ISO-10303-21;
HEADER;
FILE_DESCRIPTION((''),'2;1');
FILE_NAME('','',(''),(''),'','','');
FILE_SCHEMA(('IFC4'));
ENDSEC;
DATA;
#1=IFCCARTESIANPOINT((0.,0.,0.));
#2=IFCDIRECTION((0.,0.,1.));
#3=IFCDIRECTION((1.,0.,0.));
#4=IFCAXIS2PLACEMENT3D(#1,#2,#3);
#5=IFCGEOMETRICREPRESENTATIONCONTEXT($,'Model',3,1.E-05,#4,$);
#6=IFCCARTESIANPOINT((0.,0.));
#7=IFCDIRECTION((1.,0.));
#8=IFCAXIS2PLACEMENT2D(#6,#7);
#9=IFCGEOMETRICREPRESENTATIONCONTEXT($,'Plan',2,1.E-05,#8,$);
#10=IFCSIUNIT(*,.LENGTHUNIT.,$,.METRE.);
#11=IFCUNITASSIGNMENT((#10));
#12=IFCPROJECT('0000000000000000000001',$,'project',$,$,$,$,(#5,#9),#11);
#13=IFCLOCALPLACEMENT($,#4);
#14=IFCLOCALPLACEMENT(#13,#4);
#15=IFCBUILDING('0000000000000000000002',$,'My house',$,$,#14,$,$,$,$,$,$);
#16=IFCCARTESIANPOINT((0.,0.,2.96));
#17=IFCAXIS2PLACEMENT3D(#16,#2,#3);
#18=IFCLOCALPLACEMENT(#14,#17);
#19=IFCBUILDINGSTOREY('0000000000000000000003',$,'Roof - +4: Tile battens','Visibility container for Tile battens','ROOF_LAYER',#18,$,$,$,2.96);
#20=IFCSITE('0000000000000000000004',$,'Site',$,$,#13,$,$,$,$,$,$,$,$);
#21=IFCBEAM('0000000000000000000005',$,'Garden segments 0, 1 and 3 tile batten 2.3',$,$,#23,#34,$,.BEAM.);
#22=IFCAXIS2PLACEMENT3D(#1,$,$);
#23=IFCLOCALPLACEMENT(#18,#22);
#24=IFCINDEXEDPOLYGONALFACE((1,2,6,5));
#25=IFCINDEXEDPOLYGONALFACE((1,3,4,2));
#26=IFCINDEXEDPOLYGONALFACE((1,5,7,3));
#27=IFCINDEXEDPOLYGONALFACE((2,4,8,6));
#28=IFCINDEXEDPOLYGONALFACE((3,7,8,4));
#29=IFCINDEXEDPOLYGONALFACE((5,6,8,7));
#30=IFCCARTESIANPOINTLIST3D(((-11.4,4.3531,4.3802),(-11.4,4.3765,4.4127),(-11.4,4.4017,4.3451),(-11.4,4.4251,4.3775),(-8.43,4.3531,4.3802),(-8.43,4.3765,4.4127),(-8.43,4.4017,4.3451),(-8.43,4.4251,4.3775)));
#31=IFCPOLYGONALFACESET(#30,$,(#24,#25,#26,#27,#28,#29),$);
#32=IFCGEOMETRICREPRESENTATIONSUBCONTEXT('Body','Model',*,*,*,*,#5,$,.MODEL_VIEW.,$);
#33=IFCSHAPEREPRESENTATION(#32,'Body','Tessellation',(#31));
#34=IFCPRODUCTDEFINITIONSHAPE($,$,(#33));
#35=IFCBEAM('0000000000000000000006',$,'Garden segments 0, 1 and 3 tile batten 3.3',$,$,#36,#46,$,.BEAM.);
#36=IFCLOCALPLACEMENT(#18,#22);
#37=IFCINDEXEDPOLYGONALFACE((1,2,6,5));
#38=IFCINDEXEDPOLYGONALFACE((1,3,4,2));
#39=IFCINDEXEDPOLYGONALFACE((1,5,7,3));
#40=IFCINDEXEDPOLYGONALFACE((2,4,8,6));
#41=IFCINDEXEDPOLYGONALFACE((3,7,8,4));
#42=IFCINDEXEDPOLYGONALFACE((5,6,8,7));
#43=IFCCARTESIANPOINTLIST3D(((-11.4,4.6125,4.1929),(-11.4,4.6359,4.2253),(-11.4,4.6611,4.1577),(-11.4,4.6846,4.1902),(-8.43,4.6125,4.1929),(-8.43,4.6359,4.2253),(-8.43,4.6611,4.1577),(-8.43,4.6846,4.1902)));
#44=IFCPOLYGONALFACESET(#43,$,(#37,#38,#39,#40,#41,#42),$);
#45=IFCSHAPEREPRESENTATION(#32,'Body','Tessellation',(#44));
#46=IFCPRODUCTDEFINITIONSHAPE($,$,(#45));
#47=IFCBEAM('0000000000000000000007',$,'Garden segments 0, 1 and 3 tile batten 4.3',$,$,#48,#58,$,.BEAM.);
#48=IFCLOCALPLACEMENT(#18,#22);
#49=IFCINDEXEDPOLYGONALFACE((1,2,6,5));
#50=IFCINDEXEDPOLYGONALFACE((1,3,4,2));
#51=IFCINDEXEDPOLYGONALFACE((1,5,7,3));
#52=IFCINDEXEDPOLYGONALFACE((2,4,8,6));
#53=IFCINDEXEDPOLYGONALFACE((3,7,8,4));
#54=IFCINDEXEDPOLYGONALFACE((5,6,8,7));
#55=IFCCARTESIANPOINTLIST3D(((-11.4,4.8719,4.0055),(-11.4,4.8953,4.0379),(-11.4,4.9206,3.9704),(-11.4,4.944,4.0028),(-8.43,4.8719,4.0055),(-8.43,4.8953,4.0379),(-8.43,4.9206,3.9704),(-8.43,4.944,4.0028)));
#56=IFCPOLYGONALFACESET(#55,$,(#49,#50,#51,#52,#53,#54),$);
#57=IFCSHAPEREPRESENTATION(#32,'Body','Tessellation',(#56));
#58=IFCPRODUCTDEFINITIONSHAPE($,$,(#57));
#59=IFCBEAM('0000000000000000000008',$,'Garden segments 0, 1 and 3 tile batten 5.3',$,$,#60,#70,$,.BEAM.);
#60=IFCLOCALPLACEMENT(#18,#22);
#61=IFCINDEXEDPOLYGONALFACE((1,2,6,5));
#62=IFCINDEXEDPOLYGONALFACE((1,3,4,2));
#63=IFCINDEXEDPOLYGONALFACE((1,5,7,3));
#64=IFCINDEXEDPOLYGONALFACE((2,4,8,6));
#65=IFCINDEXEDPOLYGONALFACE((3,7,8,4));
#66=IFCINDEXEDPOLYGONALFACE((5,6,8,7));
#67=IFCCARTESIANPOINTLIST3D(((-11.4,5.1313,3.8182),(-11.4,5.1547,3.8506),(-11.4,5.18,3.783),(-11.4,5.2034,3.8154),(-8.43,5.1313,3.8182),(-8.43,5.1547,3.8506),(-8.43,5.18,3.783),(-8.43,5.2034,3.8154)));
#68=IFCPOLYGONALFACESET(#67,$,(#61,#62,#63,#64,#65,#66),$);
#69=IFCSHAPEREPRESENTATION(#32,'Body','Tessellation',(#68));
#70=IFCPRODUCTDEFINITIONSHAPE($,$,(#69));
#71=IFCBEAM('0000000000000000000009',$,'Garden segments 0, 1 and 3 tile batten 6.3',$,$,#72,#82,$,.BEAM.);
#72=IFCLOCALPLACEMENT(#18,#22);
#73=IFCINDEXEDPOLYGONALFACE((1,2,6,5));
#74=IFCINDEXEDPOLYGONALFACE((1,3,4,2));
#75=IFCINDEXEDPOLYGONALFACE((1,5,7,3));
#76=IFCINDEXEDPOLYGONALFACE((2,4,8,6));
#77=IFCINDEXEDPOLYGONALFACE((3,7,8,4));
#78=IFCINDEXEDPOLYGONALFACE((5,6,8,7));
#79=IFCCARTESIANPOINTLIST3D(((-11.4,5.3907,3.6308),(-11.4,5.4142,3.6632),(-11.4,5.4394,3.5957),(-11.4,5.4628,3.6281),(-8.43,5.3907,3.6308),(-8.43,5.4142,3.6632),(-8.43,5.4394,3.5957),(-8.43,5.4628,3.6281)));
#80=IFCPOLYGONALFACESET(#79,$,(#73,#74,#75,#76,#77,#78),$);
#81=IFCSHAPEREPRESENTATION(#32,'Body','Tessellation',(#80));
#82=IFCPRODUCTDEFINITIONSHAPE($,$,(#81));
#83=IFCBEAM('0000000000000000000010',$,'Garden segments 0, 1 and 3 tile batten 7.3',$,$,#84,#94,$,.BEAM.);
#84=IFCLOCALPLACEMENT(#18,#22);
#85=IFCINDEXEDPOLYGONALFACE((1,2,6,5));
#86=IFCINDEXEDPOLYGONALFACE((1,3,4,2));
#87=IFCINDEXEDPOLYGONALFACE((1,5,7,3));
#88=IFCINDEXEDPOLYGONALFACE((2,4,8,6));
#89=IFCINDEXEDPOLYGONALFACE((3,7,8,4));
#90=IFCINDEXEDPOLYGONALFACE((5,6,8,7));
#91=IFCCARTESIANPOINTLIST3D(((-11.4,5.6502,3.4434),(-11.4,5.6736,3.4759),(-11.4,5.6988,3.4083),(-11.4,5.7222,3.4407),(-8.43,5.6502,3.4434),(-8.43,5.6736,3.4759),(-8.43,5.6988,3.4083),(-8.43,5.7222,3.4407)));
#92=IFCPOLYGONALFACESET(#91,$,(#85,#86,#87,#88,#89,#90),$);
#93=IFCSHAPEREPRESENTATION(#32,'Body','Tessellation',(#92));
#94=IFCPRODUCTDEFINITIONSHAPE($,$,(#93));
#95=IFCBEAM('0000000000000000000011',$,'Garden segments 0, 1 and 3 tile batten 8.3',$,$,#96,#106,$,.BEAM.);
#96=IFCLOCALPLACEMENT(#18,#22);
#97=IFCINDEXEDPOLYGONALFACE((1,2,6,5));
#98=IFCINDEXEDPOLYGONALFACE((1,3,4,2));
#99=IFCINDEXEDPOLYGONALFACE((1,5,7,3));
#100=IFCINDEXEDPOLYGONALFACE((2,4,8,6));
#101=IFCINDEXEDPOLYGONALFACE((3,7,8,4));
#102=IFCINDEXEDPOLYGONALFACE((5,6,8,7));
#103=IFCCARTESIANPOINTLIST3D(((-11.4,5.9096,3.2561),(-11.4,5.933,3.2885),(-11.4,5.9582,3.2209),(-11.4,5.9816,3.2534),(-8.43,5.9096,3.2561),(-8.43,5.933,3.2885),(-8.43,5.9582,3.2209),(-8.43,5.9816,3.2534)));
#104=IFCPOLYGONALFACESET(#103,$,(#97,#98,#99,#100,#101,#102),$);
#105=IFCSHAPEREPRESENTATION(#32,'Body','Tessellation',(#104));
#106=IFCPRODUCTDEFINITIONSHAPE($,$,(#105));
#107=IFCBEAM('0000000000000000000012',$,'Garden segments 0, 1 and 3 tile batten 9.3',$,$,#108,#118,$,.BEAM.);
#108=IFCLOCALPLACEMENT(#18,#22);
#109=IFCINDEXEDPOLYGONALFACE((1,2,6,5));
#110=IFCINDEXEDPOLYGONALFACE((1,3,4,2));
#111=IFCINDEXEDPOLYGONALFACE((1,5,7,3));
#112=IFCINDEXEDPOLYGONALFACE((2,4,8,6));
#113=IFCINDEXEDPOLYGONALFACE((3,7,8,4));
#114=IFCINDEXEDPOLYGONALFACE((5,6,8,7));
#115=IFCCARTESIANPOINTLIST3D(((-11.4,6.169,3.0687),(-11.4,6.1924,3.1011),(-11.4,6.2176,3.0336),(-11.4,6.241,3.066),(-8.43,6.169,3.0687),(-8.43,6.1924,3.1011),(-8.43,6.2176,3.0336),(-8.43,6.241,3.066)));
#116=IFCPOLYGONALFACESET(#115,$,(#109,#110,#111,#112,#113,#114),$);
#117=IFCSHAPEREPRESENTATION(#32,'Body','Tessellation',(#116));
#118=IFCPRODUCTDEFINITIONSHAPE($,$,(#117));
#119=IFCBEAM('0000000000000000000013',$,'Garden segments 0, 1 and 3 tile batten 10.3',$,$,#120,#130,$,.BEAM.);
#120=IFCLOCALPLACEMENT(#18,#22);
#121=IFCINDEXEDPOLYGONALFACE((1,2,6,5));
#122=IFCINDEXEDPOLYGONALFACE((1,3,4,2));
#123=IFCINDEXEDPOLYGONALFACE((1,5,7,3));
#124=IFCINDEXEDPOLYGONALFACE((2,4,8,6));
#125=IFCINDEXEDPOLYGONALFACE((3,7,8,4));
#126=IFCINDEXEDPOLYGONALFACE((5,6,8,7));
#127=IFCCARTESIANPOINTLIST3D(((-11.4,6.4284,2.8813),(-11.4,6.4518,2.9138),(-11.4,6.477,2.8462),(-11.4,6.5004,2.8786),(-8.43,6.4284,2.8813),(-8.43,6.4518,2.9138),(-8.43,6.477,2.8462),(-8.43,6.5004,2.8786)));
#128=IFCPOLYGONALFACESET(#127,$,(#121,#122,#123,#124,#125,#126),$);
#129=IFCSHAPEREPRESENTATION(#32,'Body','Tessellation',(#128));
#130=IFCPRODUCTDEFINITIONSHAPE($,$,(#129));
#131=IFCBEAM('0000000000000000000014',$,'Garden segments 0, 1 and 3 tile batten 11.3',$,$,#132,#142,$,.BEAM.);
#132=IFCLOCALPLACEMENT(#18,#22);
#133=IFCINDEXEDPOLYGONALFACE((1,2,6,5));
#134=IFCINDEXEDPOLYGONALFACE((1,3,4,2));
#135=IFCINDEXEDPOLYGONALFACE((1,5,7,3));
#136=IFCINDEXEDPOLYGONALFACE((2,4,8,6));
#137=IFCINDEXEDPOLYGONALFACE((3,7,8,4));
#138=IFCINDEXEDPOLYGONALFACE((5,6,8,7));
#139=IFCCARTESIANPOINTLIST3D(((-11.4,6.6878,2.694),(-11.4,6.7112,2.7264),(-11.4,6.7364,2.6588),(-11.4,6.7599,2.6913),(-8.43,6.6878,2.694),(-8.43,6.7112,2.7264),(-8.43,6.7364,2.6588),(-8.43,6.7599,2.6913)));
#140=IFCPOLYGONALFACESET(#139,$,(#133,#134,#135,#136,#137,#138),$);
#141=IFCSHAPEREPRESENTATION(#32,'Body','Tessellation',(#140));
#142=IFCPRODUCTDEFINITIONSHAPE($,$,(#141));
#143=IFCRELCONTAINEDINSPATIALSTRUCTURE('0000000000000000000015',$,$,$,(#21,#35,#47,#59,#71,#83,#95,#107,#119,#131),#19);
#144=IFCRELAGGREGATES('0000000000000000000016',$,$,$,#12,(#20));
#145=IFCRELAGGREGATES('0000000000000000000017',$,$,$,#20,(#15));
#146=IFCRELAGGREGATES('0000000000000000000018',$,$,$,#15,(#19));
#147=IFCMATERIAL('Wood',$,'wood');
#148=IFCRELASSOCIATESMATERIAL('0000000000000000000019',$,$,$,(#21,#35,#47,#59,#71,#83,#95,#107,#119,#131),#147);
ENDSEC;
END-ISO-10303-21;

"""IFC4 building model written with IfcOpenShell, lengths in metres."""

from ifc_helpers import new_model, si_unit, frame, origin_with_axes, origin_2d_with_axis, place, context, subcontext, project, spatial, rectangle, extrude, clip, halfspace, source, transform, mapped, material, element, save


model = new_model("IFC4")

# Units and contexts
model_context = context("Model", 3, precision=1e-05, world=origin_with_axes())
plan_context = context("Plan", 2, precision=1e-05, world=origin_2d_with_axis())
body_context = subcontext(model_context, "Body", "Model", "MODEL_VIEW")
ifc_project = project(units=[si_unit("LENGTHUNIT", "METRE")], contexts=[model_context, plan_context])

# Site, building, storey
site_placement = place(None, origin_with_axes())
site = spatial("IfcSite", under=ifc_project, at=site_placement, Name="Site")
building_placement = place(site_placement, origin_with_axes())
building = spatial("IfcBuilding", under=site, at=building_placement, Name="My house")
storey_placement = place(building_placement, frame((0.0, 0.0, 2.96), z_axis=(0.0, 0.0, 1.0), x_axis=(1.0, 0.0, 0.0)))
storey = spatial("IfcBuildingStorey", under=building, at=storey_placement, Name="Roof - +4: Tile battens", Description="Visibility container for Tile battens", ObjectType="ROOF_LAYER", Elevation=2.96)

# Beams
ifc_material = material(Name="Wood", Category="wood")
shared_shape_1 = source(origin_with_axes(), body_context, "Body", "Clipping", [
    clip(clip(extrude(rectangle(XDim=0.06, YDim=0.04), frame((0.0, 0.0, 0.0), z_axis=(1.0, 0.0, 0.0), x_axis=(0.0, 1.0, 0.0)), (0.0, 0.0, 1.0), 2.97), halfspace(frame((-8.43, 3.9816, -6.1772), z_axis=(0.0, -0.810664, -0.585512), x_axis=(-1.0, 0.0, 0.0)), False)), halfspace(frame((-8.43, 7.8322, -3.396), z_axis=(0.0, 0.810664, 0.585512), x_axis=(1.0, 0.0, 0.0)), False)),
])
beam_1_placement = place(storey_placement, frame((-8.43, 4.3891, 4.3789), z_axis=(0.0, 0.585512, 0.810664), x_axis=(1.0, 0.0, 0.0)))
element("IfcBeam", 1, at=beam_1_placement, inside=storey, material=ifc_material, Name="Garden segments 0, 1 and 3 tile batten 2.3", PredefinedType="BEAM", context=body_context, shape_type="MappedRepresentation", body=[
    mapped(shared_shape_1, transform((0.0, 0.0, 0.0), x_axis=(-1.0, 0.0, 0.0), y_axis=(0.0, 1.0, 0.0), z_axis=(0.0, 0.0, 1.0), scale=1.0)),
])
shared_shape_2 = source(origin_with_axes(), body_context, "Body", "Clipping", [
    clip(clip(extrude(rectangle(XDim=0.06, YDim=0.04), frame((0.0, 0.0, 0.0), z_axis=(1.0, 0.0, 0.0), x_axis=(0.0, 1.0, 0.0)), (0.0, 0.0, 1.0), 2.97), halfspace(frame((-8.43, 3.6616, -6.1772), z_axis=(0.0, -0.810664, -0.585512), x_axis=(-1.0, 0.0, 0.0)), False)), halfspace(frame((-8.43, 7.5122, -3.396), z_axis=(0.0, 0.810664, 0.585512), x_axis=(1.0, 0.0, 0.0)), False)),
])
beam_2_placement = place(storey_placement, frame((-8.43, 4.6485, 4.1915), z_axis=(0.0, 0.585512, 0.810664), x_axis=(1.0, 0.0, 0.0)))
element("IfcBeam", 2, at=beam_2_placement, inside=storey, material=ifc_material, Name="Garden segments 0, 1 and 3 tile batten 3.3", PredefinedType="BEAM", context=body_context, shape_type="MappedRepresentation", body=[
    mapped(shared_shape_2, transform((0.0, 0.0, 0.0), x_axis=(-1.0, 0.0, 0.0), y_axis=(0.0, 1.0, 0.0), z_axis=(0.0, 0.0, 1.0), scale=1.0)),
])
shared_shape_3 = source(origin_with_axes(), body_context, "Body", "Clipping", [
    clip(clip(extrude(rectangle(XDim=0.06, YDim=0.04), frame((0.0, 0.0, 0.0), z_axis=(1.0, 0.0, 0.0), x_axis=(0.0, 1.0, 0.0)), (0.0, 0.0, 1.0), 2.97), halfspace(frame((-8.43, 3.3416, -6.1772), z_axis=(0.0, -0.810664, -0.585512), x_axis=(-1.0, 0.0, 0.0)), False)), halfspace(frame((-8.43, 7.1922, -3.396), z_axis=(0.0, 0.810664, 0.585512), x_axis=(1.0, 0.0, 0.0)), False)),
])
beam_3_placement = place(storey_placement, frame((-8.43, 4.9079, 4.0042), z_axis=(0.0, 0.585512, 0.810664), x_axis=(1.0, 0.0, 0.0)))
element("IfcBeam", 3, at=beam_3_placement, inside=storey, material=ifc_material, Name="Garden segments 0, 1 and 3 tile batten 4.3", PredefinedType="BEAM", context=body_context, shape_type="MappedRepresentation", body=[
    mapped(shared_shape_3, transform((0.0, 0.0, 0.0), x_axis=(-1.0, 0.0, 0.0), y_axis=(0.0, 1.0, 0.0), z_axis=(0.0, 0.0, 1.0), scale=1.0)),
])
shared_shape_4 = source(origin_with_axes(), body_context, "Body", "Clipping", [
    clip(clip(extrude(rectangle(XDim=0.06, YDim=0.04), frame((0.0, 0.0, 0.0), z_axis=(1.0, 0.0, 0.0), x_axis=(0.0, 1.0, 0.0)), (0.0, 0.0, 1.0), 2.97), halfspace(frame((-8.43, 3.0216, -6.1772), z_axis=(0.0, -0.810664, -0.585512), x_axis=(-1.0, 0.0, 0.0)), False)), halfspace(frame((-8.43, 6.8722, -3.396), z_axis=(0.0, 0.810664, 0.585512), x_axis=(1.0, 0.0, 0.0)), False)),
])
beam_4_placement = place(storey_placement, frame((-8.43, 5.1674, 3.8168), z_axis=(0.0, 0.585512, 0.810664), x_axis=(1.0, 0.0, 0.0)))
element("IfcBeam", 4, at=beam_4_placement, inside=storey, material=ifc_material, Name="Garden segments 0, 1 and 3 tile batten 5.3", PredefinedType="BEAM", context=body_context, shape_type="MappedRepresentation", body=[
    mapped(shared_shape_4, transform((0.0, 0.0, 0.0), x_axis=(-1.0, 0.0, 0.0), y_axis=(0.0, 1.0, 0.0), z_axis=(0.0, 0.0, 1.0), scale=1.0)),
])
shared_shape_5 = source(origin_with_axes(), body_context, "Body", "Clipping", [
    clip(clip(extrude(rectangle(XDim=0.06, YDim=0.04), frame((0.0, 0.0, 0.0), z_axis=(1.0, 0.0, 0.0), x_axis=(0.0, 1.0, 0.0)), (0.0, 0.0, 1.0), 2.97), halfspace(frame((-8.43, 2.7016, -6.1772), z_axis=(0.0, -0.810664, -0.585512), x_axis=(-1.0, 0.0, 0.0)), False)), halfspace(frame((-8.43, 6.5522, -3.396), z_axis=(0.0, 0.810664, 0.585512), x_axis=(1.0, 0.0, 0.0)), False)),
])
beam_5_placement = place(storey_placement, frame((-8.43, 5.4268, 3.6294), z_axis=(0.0, 0.585512, 0.810664), x_axis=(1.0, 0.0, 0.0)))
element("IfcBeam", 5, at=beam_5_placement, inside=storey, material=ifc_material, Name="Garden segments 0, 1 and 3 tile batten 6.3", PredefinedType="BEAM", context=body_context, shape_type="MappedRepresentation", body=[
    mapped(shared_shape_5, transform((0.0, 0.0, 0.0), x_axis=(-1.0, 0.0, 0.0), y_axis=(0.0, 1.0, 0.0), z_axis=(0.0, 0.0, 1.0), scale=1.0)),
])
shared_shape_6 = source(origin_with_axes(), body_context, "Body", "Clipping", [
    clip(clip(extrude(rectangle(XDim=0.06, YDim=0.04), frame((0.0, 0.0, 0.0), z_axis=(1.0, 0.0, 0.0), x_axis=(0.0, 1.0, 0.0)), (0.0, 0.0, 1.0), 2.97), halfspace(frame((-8.43, 2.3816, -6.1772), z_axis=(0.0, -0.810664, -0.585512), x_axis=(-1.0, 0.0, 0.0)), False)), halfspace(frame((-8.43, 6.2322, -3.396), z_axis=(0.0, 0.810664, 0.585512), x_axis=(1.0, 0.0, 0.0)), False)),
])
beam_6_placement = place(storey_placement, frame((-8.43, 5.6862, 3.4421), z_axis=(0.0, 0.585512, 0.810664), x_axis=(1.0, 0.0, 0.0)))
element("IfcBeam", 6, at=beam_6_placement, inside=storey, material=ifc_material, Name="Garden segments 0, 1 and 3 tile batten 7.3", PredefinedType="BEAM", context=body_context, shape_type="MappedRepresentation", body=[
    mapped(shared_shape_6, transform((0.0, 0.0, 0.0), x_axis=(-1.0, 0.0, 0.0), y_axis=(0.0, 1.0, 0.0), z_axis=(0.0, 0.0, 1.0), scale=1.0)),
])
shared_shape_7 = source(origin_with_axes(), body_context, "Body", "Clipping", [
    clip(clip(extrude(rectangle(XDim=0.06, YDim=0.04), frame((0.0, 0.0, 0.0), z_axis=(1.0, 0.0, 0.0), x_axis=(0.0, 1.0, 0.0)), (0.0, 0.0, 1.0), 2.97), halfspace(frame((-8.43, 2.0616, -6.1772), z_axis=(0.0, -0.810664, -0.585512), x_axis=(-1.0, 0.0, 0.0)), False)), halfspace(frame((-8.43, 5.9122, -3.396), z_axis=(0.0, 0.810664, 0.585512), x_axis=(1.0, 0.0, 0.0)), False)),
])
beam_7_placement = place(storey_placement, frame((-8.43, 5.9456, 3.2547), z_axis=(0.0, 0.585512, 0.810664), x_axis=(1.0, 0.0, 0.0)))
element("IfcBeam", 7, at=beam_7_placement, inside=storey, material=ifc_material, Name="Garden segments 0, 1 and 3 tile batten 8.3", PredefinedType="BEAM", context=body_context, shape_type="MappedRepresentation", body=[
    mapped(shared_shape_7, transform((0.0, 0.0, 0.0), x_axis=(-1.0, 0.0, 0.0), y_axis=(0.0, 1.0, 0.0), z_axis=(0.0, 0.0, 1.0), scale=1.0)),
])
shared_shape_8 = source(origin_with_axes(), body_context, "Body", "Clipping", [
    clip(clip(extrude(rectangle(XDim=0.06, YDim=0.04), frame((0.0, 0.0, 0.0), z_axis=(1.0, 0.0, 0.0), x_axis=(0.0, 1.0, 0.0)), (0.0, 0.0, 1.0), 2.97), halfspace(frame((-8.43, 1.7416, -6.1772), z_axis=(0.0, -0.810664, -0.585512), x_axis=(-1.0, 0.0, 0.0)), False)), halfspace(frame((-8.43, 5.5922, -3.396), z_axis=(0.0, 0.810664, 0.585512), x_axis=(1.0, 0.0, 0.0)), False)),
])
beam_8_placement = place(storey_placement, frame((-8.43, 6.205, 3.0673), z_axis=(0.0, 0.585512, 0.810664), x_axis=(1.0, 0.0, 0.0)))
element("IfcBeam", 8, at=beam_8_placement, inside=storey, material=ifc_material, Name="Garden segments 0, 1 and 3 tile batten 9.3", PredefinedType="BEAM", context=body_context, shape_type="MappedRepresentation", body=[
    mapped(shared_shape_8, transform((0.0, 0.0, 0.0), x_axis=(-1.0, 0.0, 0.0), y_axis=(0.0, 1.0, 0.0), z_axis=(0.0, 0.0, 1.0), scale=1.0)),
])
shared_shape_9 = source(origin_with_axes(), body_context, "Body", "Clipping", [
    clip(clip(extrude(rectangle(XDim=0.06, YDim=0.04), frame((0.0, 0.0, 0.0), z_axis=(1.0, 0.0, 0.0), x_axis=(0.0, 1.0, 0.0)), (0.0, 0.0, 1.0), 2.97), halfspace(frame((-8.43, 1.4216, -6.1772), z_axis=(0.0, -0.810664, -0.585512), x_axis=(-1.0, 0.0, 0.0)), False)), halfspace(frame((-8.43, 5.2722, -3.396), z_axis=(0.0, 0.810664, 0.585512), x_axis=(1.0, 0.0, 0.0)), False)),
])
beam_9_placement = place(storey_placement, frame((-8.43, 6.4644, 2.88), z_axis=(0.0, 0.585512, 0.810664), x_axis=(1.0, 0.0, 0.0)))
element("IfcBeam", 9, at=beam_9_placement, inside=storey, material=ifc_material, Name="Garden segments 0, 1 and 3 tile batten 10.3", PredefinedType="BEAM", context=body_context, shape_type="MappedRepresentation", body=[
    mapped(shared_shape_9, transform((0.0, 0.0, 0.0), x_axis=(-1.0, 0.0, 0.0), y_axis=(0.0, 1.0, 0.0), z_axis=(0.0, 0.0, 1.0), scale=1.0)),
])
shared_shape_10 = source(origin_with_axes(), body_context, "Body", "Clipping", [
    clip(clip(extrude(rectangle(XDim=0.06, YDim=0.04), frame((0.0, 0.0, 0.0), z_axis=(1.0, 0.0, 0.0), x_axis=(0.0, 1.0, 0.0)), (0.0, 0.0, 1.0), 2.97), halfspace(frame((-8.43, 1.1016, -6.1772), z_axis=(0.0, -0.810664, -0.585512), x_axis=(-1.0, 0.0, 0.0)), False)), halfspace(frame((-8.43, 4.9522, -3.396), z_axis=(0.0, 0.810664, 0.585512), x_axis=(1.0, 0.0, 0.0)), False)),
])
beam_10_placement = place(storey_placement, frame((-8.43, 6.7238, 2.6926), z_axis=(0.0, 0.585512, 0.810664), x_axis=(1.0, 0.0, 0.0)))
element("IfcBeam", 10, at=beam_10_placement, inside=storey, material=ifc_material, Name="Garden segments 0, 1 and 3 tile batten 11.3", PredefinedType="BEAM", context=body_context, shape_type="MappedRepresentation", body=[
    mapped(shared_shape_10, transform((0.0, 0.0, 0.0), x_axis=(-1.0, 0.0, 0.0), y_axis=(0.0, 1.0, 0.0), z_axis=(0.0, 0.0, 1.0), scale=1.0)),
])

save(model, "model.ifc")
